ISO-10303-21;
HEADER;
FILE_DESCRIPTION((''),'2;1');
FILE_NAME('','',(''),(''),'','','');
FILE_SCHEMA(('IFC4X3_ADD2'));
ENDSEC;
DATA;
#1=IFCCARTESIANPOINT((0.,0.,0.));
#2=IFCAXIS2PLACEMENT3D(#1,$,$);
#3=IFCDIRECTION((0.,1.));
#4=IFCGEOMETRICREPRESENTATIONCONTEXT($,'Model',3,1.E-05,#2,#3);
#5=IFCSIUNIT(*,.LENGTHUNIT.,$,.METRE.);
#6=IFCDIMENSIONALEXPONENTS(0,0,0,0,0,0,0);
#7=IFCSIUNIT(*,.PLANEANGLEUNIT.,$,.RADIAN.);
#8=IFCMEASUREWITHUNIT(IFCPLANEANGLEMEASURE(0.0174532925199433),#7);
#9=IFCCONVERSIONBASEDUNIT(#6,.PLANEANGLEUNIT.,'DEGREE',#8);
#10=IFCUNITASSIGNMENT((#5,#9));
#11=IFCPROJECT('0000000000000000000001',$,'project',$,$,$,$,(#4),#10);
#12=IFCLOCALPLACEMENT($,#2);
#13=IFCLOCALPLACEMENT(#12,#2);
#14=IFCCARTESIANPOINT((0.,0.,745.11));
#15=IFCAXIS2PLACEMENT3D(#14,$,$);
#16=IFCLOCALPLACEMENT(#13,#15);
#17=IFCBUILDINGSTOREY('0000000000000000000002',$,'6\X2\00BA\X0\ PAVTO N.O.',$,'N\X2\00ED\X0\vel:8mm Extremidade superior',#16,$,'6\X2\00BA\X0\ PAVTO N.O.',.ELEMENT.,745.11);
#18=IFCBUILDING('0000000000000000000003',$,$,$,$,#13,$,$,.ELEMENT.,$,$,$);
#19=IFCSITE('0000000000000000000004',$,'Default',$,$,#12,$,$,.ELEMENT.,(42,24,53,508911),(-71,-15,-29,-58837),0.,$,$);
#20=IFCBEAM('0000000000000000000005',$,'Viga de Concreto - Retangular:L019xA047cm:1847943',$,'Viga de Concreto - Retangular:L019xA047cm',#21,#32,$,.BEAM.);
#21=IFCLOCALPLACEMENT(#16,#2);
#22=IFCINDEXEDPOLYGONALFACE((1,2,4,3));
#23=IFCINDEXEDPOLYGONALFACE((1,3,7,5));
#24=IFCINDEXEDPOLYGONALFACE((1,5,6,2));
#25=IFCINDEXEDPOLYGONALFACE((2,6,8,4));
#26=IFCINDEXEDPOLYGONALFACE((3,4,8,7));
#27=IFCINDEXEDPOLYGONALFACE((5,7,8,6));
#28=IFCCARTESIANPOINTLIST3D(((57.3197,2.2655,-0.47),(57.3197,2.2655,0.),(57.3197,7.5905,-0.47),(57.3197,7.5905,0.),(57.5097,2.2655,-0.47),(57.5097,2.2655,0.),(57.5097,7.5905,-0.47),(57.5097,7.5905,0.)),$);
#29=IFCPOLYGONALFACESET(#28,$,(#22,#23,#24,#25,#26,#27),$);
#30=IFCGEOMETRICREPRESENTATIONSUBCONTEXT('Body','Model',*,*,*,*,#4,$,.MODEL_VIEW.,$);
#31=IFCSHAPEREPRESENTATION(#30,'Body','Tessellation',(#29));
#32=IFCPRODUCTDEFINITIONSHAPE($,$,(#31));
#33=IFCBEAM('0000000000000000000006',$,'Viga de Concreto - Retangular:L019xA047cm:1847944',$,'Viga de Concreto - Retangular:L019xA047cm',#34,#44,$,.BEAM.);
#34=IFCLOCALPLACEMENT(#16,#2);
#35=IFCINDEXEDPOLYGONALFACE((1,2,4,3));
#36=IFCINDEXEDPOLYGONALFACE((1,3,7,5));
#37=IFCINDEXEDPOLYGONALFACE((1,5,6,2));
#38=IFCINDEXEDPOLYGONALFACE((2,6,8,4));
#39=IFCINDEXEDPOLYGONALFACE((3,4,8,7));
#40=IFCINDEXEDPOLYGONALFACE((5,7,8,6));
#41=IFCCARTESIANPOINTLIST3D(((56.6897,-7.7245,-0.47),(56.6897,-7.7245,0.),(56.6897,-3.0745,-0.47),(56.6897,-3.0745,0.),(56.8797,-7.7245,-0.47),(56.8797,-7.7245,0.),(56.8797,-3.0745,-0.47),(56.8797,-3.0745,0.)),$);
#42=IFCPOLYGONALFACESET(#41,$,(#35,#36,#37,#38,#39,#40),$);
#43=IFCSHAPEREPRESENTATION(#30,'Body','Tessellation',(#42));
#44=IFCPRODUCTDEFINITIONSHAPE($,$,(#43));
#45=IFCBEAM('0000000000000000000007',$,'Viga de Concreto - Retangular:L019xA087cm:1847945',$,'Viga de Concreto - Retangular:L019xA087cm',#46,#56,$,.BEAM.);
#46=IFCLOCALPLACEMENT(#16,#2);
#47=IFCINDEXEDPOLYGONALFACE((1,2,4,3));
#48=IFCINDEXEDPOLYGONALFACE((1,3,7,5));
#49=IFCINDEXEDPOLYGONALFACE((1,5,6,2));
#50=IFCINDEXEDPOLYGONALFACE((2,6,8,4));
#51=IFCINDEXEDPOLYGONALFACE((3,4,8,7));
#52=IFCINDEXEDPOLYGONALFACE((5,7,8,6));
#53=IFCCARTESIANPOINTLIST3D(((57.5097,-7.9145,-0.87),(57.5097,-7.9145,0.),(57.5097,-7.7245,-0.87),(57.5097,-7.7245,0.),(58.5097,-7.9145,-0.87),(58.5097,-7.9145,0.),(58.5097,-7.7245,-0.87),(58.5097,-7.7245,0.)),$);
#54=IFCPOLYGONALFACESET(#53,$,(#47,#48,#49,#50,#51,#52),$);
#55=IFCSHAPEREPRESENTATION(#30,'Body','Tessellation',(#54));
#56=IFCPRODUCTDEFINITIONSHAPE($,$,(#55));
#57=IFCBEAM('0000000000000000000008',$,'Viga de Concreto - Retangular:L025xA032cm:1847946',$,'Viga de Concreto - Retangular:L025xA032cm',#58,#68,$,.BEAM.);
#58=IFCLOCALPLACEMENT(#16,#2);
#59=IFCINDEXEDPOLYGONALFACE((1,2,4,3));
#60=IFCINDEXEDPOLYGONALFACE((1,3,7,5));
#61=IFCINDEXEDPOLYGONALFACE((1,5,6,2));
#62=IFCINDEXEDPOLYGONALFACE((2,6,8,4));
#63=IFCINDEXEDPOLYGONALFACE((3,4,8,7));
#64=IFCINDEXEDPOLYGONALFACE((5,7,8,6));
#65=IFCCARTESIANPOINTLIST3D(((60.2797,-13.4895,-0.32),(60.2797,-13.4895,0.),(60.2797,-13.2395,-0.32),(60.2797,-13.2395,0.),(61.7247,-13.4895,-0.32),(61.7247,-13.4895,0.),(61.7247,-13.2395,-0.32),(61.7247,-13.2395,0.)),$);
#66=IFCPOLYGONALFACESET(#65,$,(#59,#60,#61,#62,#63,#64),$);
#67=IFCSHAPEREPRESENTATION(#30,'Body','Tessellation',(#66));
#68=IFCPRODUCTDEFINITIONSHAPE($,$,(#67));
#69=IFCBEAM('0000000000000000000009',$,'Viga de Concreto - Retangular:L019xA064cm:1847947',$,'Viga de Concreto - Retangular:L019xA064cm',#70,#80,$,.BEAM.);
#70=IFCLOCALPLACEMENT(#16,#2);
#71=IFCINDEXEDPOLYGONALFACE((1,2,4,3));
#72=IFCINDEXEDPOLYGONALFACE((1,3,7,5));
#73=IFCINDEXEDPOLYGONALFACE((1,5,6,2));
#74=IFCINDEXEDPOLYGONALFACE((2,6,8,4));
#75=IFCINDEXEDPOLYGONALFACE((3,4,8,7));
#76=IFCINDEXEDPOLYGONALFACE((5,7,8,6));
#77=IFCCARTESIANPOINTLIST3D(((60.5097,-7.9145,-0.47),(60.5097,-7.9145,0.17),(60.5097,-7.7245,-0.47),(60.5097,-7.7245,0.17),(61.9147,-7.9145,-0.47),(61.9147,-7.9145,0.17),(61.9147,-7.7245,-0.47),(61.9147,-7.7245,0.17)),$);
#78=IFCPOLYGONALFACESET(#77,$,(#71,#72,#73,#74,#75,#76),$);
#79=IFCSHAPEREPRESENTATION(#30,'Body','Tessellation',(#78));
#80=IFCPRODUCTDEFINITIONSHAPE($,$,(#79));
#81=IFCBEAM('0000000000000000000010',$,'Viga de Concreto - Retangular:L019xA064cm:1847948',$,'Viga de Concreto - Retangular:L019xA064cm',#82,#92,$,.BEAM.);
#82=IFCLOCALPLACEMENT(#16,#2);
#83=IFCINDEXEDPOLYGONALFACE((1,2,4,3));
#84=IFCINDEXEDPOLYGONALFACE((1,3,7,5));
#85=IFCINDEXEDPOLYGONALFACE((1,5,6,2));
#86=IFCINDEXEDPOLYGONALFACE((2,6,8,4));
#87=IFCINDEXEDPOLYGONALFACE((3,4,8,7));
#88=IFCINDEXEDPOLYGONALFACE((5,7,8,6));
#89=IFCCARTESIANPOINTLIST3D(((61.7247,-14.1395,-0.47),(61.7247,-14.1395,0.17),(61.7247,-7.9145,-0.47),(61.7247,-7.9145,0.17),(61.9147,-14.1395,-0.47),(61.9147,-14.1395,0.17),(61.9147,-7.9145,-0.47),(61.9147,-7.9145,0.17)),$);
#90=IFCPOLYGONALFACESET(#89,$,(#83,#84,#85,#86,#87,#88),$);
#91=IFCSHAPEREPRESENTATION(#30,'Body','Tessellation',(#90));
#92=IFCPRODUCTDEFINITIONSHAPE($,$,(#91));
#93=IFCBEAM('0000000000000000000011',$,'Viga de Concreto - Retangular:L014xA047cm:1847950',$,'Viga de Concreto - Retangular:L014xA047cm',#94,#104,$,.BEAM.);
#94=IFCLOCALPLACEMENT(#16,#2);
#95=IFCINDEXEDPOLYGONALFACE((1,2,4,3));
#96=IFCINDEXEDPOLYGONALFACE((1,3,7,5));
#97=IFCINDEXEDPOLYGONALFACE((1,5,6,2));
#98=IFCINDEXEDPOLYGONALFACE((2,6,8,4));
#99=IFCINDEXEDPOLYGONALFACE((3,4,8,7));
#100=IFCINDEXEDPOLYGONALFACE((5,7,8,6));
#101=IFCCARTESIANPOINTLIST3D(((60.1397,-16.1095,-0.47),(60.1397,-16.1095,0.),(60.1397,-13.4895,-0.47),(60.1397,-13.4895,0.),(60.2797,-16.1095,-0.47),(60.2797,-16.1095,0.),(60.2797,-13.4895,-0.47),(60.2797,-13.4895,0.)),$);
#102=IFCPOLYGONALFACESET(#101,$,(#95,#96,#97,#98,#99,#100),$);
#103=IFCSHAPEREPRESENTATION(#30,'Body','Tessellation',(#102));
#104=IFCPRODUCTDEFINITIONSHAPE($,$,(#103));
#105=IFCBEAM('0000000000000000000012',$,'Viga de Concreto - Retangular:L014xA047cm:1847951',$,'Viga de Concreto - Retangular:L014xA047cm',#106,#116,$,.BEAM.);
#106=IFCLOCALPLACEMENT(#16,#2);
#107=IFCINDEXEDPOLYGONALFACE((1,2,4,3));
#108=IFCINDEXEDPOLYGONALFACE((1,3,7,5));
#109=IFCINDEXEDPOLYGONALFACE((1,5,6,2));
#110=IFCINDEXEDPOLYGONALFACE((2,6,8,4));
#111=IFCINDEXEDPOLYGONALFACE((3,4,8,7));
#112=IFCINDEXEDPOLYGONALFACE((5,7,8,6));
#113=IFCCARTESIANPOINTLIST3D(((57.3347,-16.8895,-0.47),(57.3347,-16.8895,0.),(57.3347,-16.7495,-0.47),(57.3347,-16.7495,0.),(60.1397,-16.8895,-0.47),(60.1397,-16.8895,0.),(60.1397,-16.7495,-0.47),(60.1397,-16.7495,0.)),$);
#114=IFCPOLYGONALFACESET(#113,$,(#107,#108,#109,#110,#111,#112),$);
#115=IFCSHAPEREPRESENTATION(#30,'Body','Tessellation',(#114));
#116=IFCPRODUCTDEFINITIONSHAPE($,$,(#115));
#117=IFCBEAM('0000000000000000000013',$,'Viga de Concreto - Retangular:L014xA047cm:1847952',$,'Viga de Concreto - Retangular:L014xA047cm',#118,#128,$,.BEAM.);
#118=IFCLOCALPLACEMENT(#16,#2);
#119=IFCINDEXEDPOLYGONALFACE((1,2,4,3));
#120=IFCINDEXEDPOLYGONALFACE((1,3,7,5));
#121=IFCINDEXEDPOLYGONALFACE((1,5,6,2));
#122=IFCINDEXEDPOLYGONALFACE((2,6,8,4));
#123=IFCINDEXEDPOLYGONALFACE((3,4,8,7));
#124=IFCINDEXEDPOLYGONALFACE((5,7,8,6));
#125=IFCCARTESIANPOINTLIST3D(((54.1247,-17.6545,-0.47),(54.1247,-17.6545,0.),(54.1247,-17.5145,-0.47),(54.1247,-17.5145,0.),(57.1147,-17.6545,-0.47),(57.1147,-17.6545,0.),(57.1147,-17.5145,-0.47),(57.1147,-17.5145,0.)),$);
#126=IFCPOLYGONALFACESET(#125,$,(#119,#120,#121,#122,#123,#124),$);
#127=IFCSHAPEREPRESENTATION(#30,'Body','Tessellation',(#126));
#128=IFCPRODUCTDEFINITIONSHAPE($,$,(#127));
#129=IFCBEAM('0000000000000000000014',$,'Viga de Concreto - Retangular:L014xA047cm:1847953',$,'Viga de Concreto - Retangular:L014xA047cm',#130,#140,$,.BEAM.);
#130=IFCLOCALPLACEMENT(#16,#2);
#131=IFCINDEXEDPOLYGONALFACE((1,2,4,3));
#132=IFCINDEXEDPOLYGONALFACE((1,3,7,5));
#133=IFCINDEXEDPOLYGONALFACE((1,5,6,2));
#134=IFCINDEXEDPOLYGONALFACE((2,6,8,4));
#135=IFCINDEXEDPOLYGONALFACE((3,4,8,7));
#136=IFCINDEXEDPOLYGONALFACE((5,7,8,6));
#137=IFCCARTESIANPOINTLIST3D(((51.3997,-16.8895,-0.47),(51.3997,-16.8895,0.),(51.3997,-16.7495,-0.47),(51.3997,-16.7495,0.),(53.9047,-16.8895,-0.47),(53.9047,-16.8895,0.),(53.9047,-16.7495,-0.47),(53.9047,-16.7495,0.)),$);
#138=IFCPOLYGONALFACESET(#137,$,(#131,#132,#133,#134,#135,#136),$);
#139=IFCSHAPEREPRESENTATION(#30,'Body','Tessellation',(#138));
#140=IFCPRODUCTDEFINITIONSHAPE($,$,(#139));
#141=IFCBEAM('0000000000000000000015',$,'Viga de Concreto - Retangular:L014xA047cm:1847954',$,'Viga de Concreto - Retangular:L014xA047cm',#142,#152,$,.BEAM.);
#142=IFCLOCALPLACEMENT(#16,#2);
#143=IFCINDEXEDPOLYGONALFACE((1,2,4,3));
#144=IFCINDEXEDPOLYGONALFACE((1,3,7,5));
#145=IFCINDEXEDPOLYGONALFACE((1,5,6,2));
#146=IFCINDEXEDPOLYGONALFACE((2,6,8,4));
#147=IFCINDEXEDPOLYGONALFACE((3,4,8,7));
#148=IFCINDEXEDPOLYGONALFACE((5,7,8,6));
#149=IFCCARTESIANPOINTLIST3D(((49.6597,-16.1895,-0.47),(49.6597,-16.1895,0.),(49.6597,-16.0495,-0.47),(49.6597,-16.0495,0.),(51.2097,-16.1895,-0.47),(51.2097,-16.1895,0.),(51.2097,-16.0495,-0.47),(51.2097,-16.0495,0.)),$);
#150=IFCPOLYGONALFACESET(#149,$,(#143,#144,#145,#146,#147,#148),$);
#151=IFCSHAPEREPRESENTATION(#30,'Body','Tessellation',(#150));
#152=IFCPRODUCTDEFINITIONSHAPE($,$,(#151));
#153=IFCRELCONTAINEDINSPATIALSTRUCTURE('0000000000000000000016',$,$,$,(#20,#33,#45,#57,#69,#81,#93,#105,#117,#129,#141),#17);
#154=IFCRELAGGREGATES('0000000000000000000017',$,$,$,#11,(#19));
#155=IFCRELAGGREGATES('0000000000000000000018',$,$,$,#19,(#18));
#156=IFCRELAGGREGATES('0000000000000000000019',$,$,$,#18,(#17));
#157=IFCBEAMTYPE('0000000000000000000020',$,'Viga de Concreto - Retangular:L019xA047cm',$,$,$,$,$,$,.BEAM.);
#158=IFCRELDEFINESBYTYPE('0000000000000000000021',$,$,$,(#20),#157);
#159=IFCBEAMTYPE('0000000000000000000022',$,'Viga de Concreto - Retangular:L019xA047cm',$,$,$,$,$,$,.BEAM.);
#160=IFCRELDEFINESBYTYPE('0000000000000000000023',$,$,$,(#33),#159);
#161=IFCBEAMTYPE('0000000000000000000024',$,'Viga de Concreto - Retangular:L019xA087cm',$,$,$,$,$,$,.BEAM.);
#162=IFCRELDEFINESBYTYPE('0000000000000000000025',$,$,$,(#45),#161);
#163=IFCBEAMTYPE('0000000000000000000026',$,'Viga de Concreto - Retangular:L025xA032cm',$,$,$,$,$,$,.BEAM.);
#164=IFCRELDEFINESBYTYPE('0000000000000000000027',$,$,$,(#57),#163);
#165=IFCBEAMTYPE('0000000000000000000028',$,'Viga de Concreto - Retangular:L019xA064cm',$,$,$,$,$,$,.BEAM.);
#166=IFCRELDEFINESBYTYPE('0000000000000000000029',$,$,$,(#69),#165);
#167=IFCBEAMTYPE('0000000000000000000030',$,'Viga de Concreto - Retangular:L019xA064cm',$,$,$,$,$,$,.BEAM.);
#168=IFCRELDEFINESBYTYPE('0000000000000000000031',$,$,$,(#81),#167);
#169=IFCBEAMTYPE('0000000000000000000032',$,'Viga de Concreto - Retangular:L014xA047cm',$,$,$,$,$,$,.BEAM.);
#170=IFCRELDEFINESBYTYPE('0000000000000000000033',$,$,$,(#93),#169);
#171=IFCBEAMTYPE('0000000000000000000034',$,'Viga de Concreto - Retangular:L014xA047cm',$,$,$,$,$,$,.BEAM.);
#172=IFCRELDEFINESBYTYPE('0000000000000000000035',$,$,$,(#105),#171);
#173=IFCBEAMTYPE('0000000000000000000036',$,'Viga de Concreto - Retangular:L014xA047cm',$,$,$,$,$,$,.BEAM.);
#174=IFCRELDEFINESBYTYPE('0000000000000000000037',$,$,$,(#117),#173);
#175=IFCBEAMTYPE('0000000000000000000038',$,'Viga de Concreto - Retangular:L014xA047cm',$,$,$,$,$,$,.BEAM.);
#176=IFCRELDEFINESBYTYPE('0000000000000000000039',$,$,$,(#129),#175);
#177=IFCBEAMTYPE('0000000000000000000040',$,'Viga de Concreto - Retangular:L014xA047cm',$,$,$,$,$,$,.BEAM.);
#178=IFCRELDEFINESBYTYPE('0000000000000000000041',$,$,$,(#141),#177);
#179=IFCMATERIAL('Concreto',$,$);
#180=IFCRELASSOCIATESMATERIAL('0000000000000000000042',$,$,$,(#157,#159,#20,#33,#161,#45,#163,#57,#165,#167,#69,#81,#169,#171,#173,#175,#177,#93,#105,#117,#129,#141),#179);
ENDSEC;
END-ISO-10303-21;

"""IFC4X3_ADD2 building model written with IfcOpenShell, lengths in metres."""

from ifc_helpers import new_model, entity, si_unit, converted_unit, direction, frame, frame_2d, origin, origin_2d_with_axis, place, context, subcontext, project, spatial, rectangle, extrude, source, transform, mapped, material, material_profile, profile_set, profile_usage, type_object, type_shapes, element, save


model = new_model("IFC4X3_ADD2")

# Units and contexts
model_context = context("Model", 3, precision=1e-05, world=origin(), true_north=direction((0.0, 1.0)))
body_context = subcontext(model_context, "Body", "Model", "MODEL_VIEW")
ifc_project = project(units=[si_unit("LENGTHUNIT", "METRE"), converted_unit("PLANEANGLEUNIT", "DEGREE", entity("IfcPlaneAngleMeasure", 0.0174532925199433), si_unit("PLANEANGLEUNIT", "RADIAN"), dimensions=[0, 0, 0, 0, 0, 0, 0])], contexts=[model_context])

# Site, building, storey
site_placement = place(None, origin())
site = spatial("IfcSite", under=ifc_project, at=site_placement, Name="Default", CompositionType="ELEMENT", RefLatitude=(42, 24, 53, 508911), RefLongitude=(-71, -15, -29, -58837), RefElevation=0.0)
building_placement = place(site_placement, origin())
building = spatial("IfcBuilding", under=site, at=building_placement, CompositionType="ELEMENT")
storey_placement = place(building_placement, frame((0.0, 0.0, 745.11)))
storey = spatial("IfcBuildingStorey", under=building, at=storey_placement, Name="6º PAVTO N.O.", ObjectType="Nível:8mm Extremidade superior", LongName="6º PAVTO N.O.", CompositionType="ELEMENT", Elevation=745.11)

# Beams
ifc_material = material(Name="Concreto")
ifc_material_profile_1 = material_profile(ifc_material, rectangle(XDim=0.47, YDim=0.14, at=frame_2d((0.0, 0.0), x_axis=(0.0, 1.0))), Name="L014xA047cm")
ifc_profile_set_1 = profile_set([ifc_material_profile_1], Name="L014xA047cm")
ifc_profile_usage_1 = profile_usage(ifc_profile_set_1, cardinal=8)
ifc_material_profile_2 = material_profile(ifc_material, rectangle(XDim=0.64, YDim=0.19, at=frame_2d((0.0, 0.0), x_axis=(1.0, 0.0))), Name="L019xA064cm")
ifc_profile_set_2 = profile_set([ifc_material_profile_2], Name="L019xA064cm")
ifc_profile_usage_2 = profile_usage(ifc_profile_set_2, cardinal=8)
ifc_material_profile_3 = material_profile(ifc_material, rectangle(XDim=0.87, YDim=0.19, at=origin_2d_with_axis()), Name="L019xA087cm")
ifc_profile_set_3 = profile_set([ifc_material_profile_3], Name="L019xA087cm")
ifc_profile_usage_3 = profile_usage(ifc_profile_set_3, cardinal=8)
ifc_material_profile_4 = material_profile(ifc_material, rectangle(XDim=0.32, YDim=0.25, at=frame_2d((0.0, 0.0), x_axis=(1.0, 0.0))), Name="L025xA032cm")
ifc_profile_set_4 = profile_set([ifc_material_profile_4], Name="L025xA032cm")
ifc_profile_usage_4 = profile_usage(ifc_profile_set_4, cardinal=8)
ifc_material_profile_5 = material_profile(ifc_material, rectangle(XDim=0.47, YDim=0.19, at=frame_2d((0.0, 0.0), x_axis=(0.0, 1.0))), Name="L019xA047cm")
ifc_profile_set_5 = profile_set([ifc_material_profile_5], Name="L019xA047cm")
ifc_profile_usage_5 = profile_usage(ifc_profile_set_5, cardinal=8)
beam_type_1 = type_object("IfcBeamType", Name="Viga de Concreto - Retangular:L019xA047cm", PredefinedType="BEAM", material=ifc_profile_set_5)
shared_shape_1 = source(origin(), body_context, "Body", "SweptSolid", [
    extrude(rectangle(XDim=0.47, YDim=0.19, at=frame_2d((0.0, 0.0), x_axis=(0.0, 1.0))), frame((57.4147, 2.2655, 744.875), z_axis=(0.0, 1.0, 0.0), x_axis=(-1.0, 0.0, 0.0)), (0.0, 0.0, 1.0), 5.325),
])
type_shapes(beam_type_1, [shared_shape_1])
beam_1_placement = place(storey_placement, frame((0.0, 0.0, -745.11)))
element("IfcBeam", 1, at=beam_1_placement, inside=storey, type_object=beam_type_1, material=ifc_profile_usage_5, Name="Viga de Concreto - Retangular:L019xA047cm:1847943", ObjectType="Viga de Concreto - Retangular:L019xA047cm", PredefinedType="BEAM", context=body_context, shape_type="MappedRepresentation", body=[
    mapped(shared_shape_1, transform((0.0, 0.0, 0.0), scale=1.0)),
])
beam_type_2 = type_object("IfcBeamType", Name="Viga de Concreto - Retangular:L019xA047cm", PredefinedType="BEAM", material=ifc_profile_set_5)
shared_shape_2 = source(origin(), body_context, "Body", "SweptSolid", [
    extrude(rectangle(XDim=0.47, YDim=0.19, at=frame_2d((0.0, 0.0), x_axis=(0.0, 1.0))), frame((56.7847, -7.7245, 744.875), z_axis=(0.0, 1.0, 0.0), x_axis=(-1.0, 0.0, 0.0)), (0.0, 0.0, 1.0), 4.65),
])
type_shapes(beam_type_2, [shared_shape_2])
beam_2_placement = place(storey_placement, frame((0.0, 0.0, -745.11)))
element("IfcBeam", 2, at=beam_2_placement, inside=storey, type_object=beam_type_2, material=ifc_profile_usage_5, Name="Viga de Concreto - Retangular:L019xA047cm:1847944", ObjectType="Viga de Concreto - Retangular:L019xA047cm", PredefinedType="BEAM", context=body_context, shape_type="MappedRepresentation", body=[
    mapped(shared_shape_2, transform((0.0, 0.0, 0.0), scale=1.0)),
])
beam_type_3 = type_object("IfcBeamType", Name="Viga de Concreto - Retangular:L019xA087cm", PredefinedType="BEAM", material=ifc_profile_set_3)
shared_shape_3 = source(origin(), body_context, "Body", "SweptSolid", [
    extrude(rectangle(XDim=0.87, YDim=0.19, at=frame_2d((0.0, 0.0), x_axis=(1.0, 0.0))), frame((57.5097, -7.8195, 744.675), z_axis=(1.0, 0.0, 0.0), x_axis=(0.0, 0.0, -1.0)), (0.0, 0.0, 1.0), 1.0),
])
type_shapes(beam_type_3, [shared_shape_3])
beam_3_placement = place(storey_placement, frame((0.0, 0.0, -745.11)))
element("IfcBeam", 3, at=beam_3_placement, inside=storey, type_object=beam_type_3, material=ifc_profile_usage_3, Name="Viga de Concreto - Retangular:L019xA087cm:1847945", ObjectType="Viga de Concreto - Retangular:L019xA087cm", PredefinedType="BEAM", context=body_context, shape_type="MappedRepresentation", body=[
    mapped(shared_shape_3, transform((0.0, 0.0, 0.0), scale=1.0)),
])
beam_type_4 = type_object("IfcBeamType", Name="Viga de Concreto - Retangular:L025xA032cm", PredefinedType="BEAM", material=ifc_profile_set_4)
shared_shape_4 = source(origin(), body_context, "Body", "SweptSolid", [
    extrude(rectangle(XDim=0.32, YDim=0.25, at=origin_2d_with_axis()), frame((60.2797, -13.3645, 744.95), z_axis=(1.0, 0.0, 0.0), x_axis=(0.0, 0.0, -1.0)), (0.0, 0.0, 1.0), 1.445),
])
type_shapes(beam_type_4, [shared_shape_4])
beam_4_placement = place(storey_placement, frame((0.0, 0.0, -745.11)))
element("IfcBeam", 4, at=beam_4_placement, inside=storey, type_object=beam_type_4, material=ifc_profile_usage_4, Name="Viga de Concreto - Retangular:L025xA032cm:1847946", ObjectType="Viga de Concreto - Retangular:L025xA032cm", PredefinedType="BEAM", context=body_context, shape_type="MappedRepresentation", body=[
    mapped(shared_shape_4, transform((0.0, 0.0, 0.0), scale=1.0)),
])
beam_type_5 = type_object("IfcBeamType", Name="Viga de Concreto - Retangular:L019xA064cm", PredefinedType="BEAM", material=ifc_profile_set_2)
shared_shape_5 = source(origin(), body_context, "Body", "SweptSolid", [
    extrude(rectangle(XDim=0.64, YDim=0.19, at=frame_2d((0.0, 0.0), x_axis=(1.0, 0.0))), frame((60.5097, -7.8195, 744.96), z_axis=(1.0, 0.0, 0.0), x_axis=(0.0, 0.0, -1.0)), (0.0, 0.0, 1.0), 1.405),
])
type_shapes(beam_type_5, [shared_shape_5])
beam_5_placement = place(storey_placement, frame((0.0, 0.0, -745.11)))
element("IfcBeam", 5, at=beam_5_placement, inside=storey, type_object=beam_type_5, material=ifc_profile_usage_2, Name="Viga de Concreto - Retangular:L019xA064cm:1847947", ObjectType="Viga de Concreto - Retangular:L019xA064cm", PredefinedType="BEAM", context=body_context, shape_type="MappedRepresentation", body=[
    mapped(shared_shape_5, transform((0.0, 0.0, 0.0), scale=1.0)),
])
beam_type_6 = type_object("IfcBeamType", Name="Viga de Concreto - Retangular:L019xA064cm", PredefinedType="BEAM", material=ifc_profile_set_2)
shared_shape_6 = source(origin(), body_context, "Body", "SweptSolid", [
    extrude(rectangle(XDim=0.64, YDim=0.19, at=frame_2d((0.0, 0.0), x_axis=(0.0, 1.0))), frame((61.8197, -7.9145, 744.96), z_axis=(0.0, -1.0, 0.0), x_axis=(-1.0, 0.0, 0.0)), (0.0, 0.0, 1.0), 6.225),
])
type_shapes(beam_type_6, [shared_shape_6])
beam_6_placement = place(storey_placement, frame((0.0, 0.0, -745.11)))
element("IfcBeam", 6, at=beam_6_placement, inside=storey, type_object=beam_type_6, material=ifc_profile_usage_2, Name="Viga de Concreto - Retangular:L019xA064cm:1847948", ObjectType="Viga de Concreto - Retangular:L019xA064cm", PredefinedType="BEAM", context=body_context, shape_type="MappedRepresentation", body=[
    mapped(shared_shape_6, transform((0.0, 0.0, 0.0), scale=1.0)),
])
beam_type_7 = type_object("IfcBeamType", Name="Viga de Concreto - Retangular:L014xA047cm", PredefinedType="BEAM", material=ifc_profile_set_1)
shared_shape_7 = source(origin(), body_context, "Body", "SweptSolid", [
    extrude(rectangle(XDim=0.47, YDim=0.14, at=frame_2d((0.0, 0.0), x_axis=(0.0, 1.0))), frame((60.2097, -13.4895, 744.875), z_axis=(0.0, -1.0, 0.0), x_axis=(-1.0, 0.0, 0.0)), (0.0, 0.0, 1.0), 2.62),
])
type_shapes(beam_type_7, [shared_shape_7])
beam_7_placement = place(storey_placement, frame((0.0, 0.0, -745.11)))
element("IfcBeam", 7, at=beam_7_placement, inside=storey, type_object=beam_type_7, material=ifc_profile_usage_1, Name="Viga de Concreto - Retangular:L014xA047cm:1847950", ObjectType="Viga de Concreto - Retangular:L014xA047cm", PredefinedType="BEAM", context=body_context, shape_type="MappedRepresentation", body=[
    mapped(shared_shape_7, transform((0.0, 0.0, 0.0), scale=1.0)),
])
beam_type_8 = type_object("IfcBeamType", Name="Viga de Concreto - Retangular:L014xA047cm", PredefinedType="BEAM", material=ifc_profile_set_1)
shared_shape_8 = source(origin(), body_context, "Body", "SweptSolid", [
    extrude(rectangle(XDim=0.47, YDim=0.14, at=origin_2d_with_axis()), frame((60.1397, -16.8195, 744.875), z_axis=(-1.0, 0.0, 0.0), x_axis=(0.0, 0.0, -1.0)), (0.0, 0.0, 1.0), 2.805),
])
type_shapes(beam_type_8, [shared_shape_8])
beam_8_placement = place(storey_placement, frame((0.0, 0.0, -745.11)))
element("IfcBeam", 8, at=beam_8_placement, inside=storey, type_object=beam_type_8, material=ifc_profile_usage_1, Name="Viga de Concreto - Retangular:L014xA047cm:1847951", ObjectType="Viga de Concreto - Retangular:L014xA047cm", PredefinedType="BEAM", context=body_context, shape_type="MappedRepresentation", body=[
    mapped(shared_shape_8, transform((0.0, 0.0, 0.0), scale=1.0)),
])
beam_type_9 = type_object("IfcBeamType", Name="Viga de Concreto - Retangular:L014xA047cm", PredefinedType="BEAM", material=ifc_profile_set_1)
shared_shape_9 = source(origin(), body_context, "Body", "SweptSolid", [
    extrude(rectangle(XDim=0.47, YDim=0.14, at=origin_2d_with_axis()), frame((57.1147, -17.5845, 744.875), z_axis=(-1.0, 0.0, 0.0), x_axis=(0.0, 0.0, -1.0)), (0.0, 0.0, 1.0), 2.99),
])
type_shapes(beam_type_9, [shared_shape_9])
beam_9_placement = place(storey_placement, frame((0.0, 0.0, -745.11)))
element("IfcBeam", 9, at=beam_9_placement, inside=storey, type_object=beam_type_9, material=ifc_profile_usage_1, Name="Viga de Concreto - Retangular:L014xA047cm:1847952", ObjectType="Viga de Concreto - Retangular:L014xA047cm", PredefinedType="BEAM", context=body_context, shape_type="MappedRepresentation", body=[
    mapped(shared_shape_9, transform((0.0, 0.0, 0.0), scale=1.0)),
])
beam_type_10 = type_object("IfcBeamType", Name="Viga de Concreto - Retangular:L014xA047cm", PredefinedType="BEAM", material=ifc_profile_set_1)
shared_shape_10 = source(origin(), body_context, "Body", "SweptSolid", [
    extrude(rectangle(XDim=0.47, YDim=0.14, at=origin_2d_with_axis()), frame((53.9047, -16.8195, 744.875), z_axis=(-1.0, 0.0, 0.0), x_axis=(0.0, 0.0, -1.0)), (0.0, 0.0, 1.0), 2.505),
])
type_shapes(beam_type_10, [shared_shape_10])
beam_10_placement = place(storey_placement, frame((0.0, 0.0, -745.11)))
element("IfcBeam", 10, at=beam_10_placement, inside=storey, type_object=beam_type_10, material=ifc_profile_usage_1, Name="Viga de Concreto - Retangular:L014xA047cm:1847953", ObjectType="Viga de Concreto - Retangular:L014xA047cm", PredefinedType="BEAM", context=body_context, shape_type="MappedRepresentation", body=[
    mapped(shared_shape_10, transform((0.0, 0.0, 0.0), scale=1.0)),
])
beam_type_11 = type_object("IfcBeamType", Name="Viga de Concreto - Retangular:L014xA047cm", PredefinedType="BEAM", material=ifc_profile_set_1)
shared_shape_11 = source(origin(), body_context, "Body", "SweptSolid", [
    extrude(rectangle(XDim=0.47, YDim=0.14, at=origin_2d_with_axis()), frame((51.2097, -16.1195, 744.875), z_axis=(-1.0, 0.0, 0.0), x_axis=(0.0, 0.0, -1.0)), (0.0, 0.0, 1.0), 1.55),
])
type_shapes(beam_type_11, [shared_shape_11])
beam_11_placement = place(storey_placement, frame((0.0, 0.0, -745.11)))
element("IfcBeam", 11, at=beam_11_placement, inside=storey, type_object=beam_type_11, material=ifc_profile_usage_1, Name="Viga de Concreto - Retangular:L014xA047cm:1847954", ObjectType="Viga de Concreto - Retangular:L014xA047cm", PredefinedType="BEAM", context=body_context, shape_type="MappedRepresentation", body=[
    mapped(shared_shape_11, transform((0.0, 0.0, 0.0), scale=1.0)),
])

save(model, "model.ifc")
